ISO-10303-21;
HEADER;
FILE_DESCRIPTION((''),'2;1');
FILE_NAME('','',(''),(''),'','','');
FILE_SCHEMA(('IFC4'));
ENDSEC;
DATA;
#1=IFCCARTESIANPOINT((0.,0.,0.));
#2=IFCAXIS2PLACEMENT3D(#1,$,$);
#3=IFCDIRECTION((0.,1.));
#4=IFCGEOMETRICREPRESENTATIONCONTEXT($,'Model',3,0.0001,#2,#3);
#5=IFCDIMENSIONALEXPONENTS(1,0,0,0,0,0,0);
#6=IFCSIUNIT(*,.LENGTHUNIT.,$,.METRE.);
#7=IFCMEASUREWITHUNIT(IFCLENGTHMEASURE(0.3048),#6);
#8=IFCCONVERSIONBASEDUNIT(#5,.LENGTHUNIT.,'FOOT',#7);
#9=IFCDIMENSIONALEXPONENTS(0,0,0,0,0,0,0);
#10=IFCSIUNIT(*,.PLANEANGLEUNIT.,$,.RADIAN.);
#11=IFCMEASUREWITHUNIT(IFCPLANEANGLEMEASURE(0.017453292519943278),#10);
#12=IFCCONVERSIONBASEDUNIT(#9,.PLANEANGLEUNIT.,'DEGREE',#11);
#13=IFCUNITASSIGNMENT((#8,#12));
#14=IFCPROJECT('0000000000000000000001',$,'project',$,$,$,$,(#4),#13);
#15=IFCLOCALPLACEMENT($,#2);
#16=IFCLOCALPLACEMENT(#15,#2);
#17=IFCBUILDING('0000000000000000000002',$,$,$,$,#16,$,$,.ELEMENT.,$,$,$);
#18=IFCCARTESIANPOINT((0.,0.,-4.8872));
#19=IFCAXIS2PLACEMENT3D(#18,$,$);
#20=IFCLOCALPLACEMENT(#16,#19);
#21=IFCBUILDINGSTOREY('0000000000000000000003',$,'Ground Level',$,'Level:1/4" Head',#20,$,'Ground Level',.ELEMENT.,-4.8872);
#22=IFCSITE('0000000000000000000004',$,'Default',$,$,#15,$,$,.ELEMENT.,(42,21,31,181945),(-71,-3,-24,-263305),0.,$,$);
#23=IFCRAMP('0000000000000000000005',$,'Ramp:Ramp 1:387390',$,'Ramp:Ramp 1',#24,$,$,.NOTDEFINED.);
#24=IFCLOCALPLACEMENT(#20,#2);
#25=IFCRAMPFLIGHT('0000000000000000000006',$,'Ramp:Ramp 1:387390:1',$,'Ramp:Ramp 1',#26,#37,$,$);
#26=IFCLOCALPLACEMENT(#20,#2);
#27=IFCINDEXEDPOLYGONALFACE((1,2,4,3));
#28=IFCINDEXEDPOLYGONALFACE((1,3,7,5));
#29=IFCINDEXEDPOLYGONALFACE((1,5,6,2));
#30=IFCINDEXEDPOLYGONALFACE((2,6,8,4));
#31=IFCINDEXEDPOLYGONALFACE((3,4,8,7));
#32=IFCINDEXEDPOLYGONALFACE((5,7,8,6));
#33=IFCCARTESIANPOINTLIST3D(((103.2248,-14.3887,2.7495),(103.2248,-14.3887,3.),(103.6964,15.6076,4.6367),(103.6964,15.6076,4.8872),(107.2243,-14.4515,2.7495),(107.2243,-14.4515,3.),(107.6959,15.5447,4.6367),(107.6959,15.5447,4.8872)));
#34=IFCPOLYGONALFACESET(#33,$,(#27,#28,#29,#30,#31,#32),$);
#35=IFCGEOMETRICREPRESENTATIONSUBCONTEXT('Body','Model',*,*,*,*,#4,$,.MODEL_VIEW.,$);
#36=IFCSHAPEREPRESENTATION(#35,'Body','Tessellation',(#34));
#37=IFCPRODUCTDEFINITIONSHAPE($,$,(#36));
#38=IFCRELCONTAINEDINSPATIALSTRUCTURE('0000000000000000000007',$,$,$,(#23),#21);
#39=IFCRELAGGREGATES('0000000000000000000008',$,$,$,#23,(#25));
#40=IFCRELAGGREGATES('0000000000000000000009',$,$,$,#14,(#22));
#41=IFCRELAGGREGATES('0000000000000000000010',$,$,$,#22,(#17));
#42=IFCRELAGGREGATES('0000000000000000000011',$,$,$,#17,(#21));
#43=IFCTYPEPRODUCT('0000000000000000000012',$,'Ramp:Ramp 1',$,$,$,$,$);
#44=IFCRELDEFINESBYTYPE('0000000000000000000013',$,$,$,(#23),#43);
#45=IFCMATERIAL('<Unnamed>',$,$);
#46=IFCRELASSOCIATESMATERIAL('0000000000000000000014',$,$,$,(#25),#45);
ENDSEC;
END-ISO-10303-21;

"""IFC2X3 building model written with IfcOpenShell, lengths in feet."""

from ifc_helpers import new_model, entity, si_unit, converted_unit, direction, frame, origin, place, context, subcontext, project, spatial, polyline, outline, extrude, material, type_object, element, aggregate, save


model = new_model("IFC2X3")

# Units and contexts
model_context = context("Model", 3, precision=0.0001, world=origin(), true_north=direction((0.0, 1.0)))
body_context = subcontext(model_context, "Body", "Model", "MODEL_VIEW")
ifc_project = project(units=[converted_unit("LENGTHUNIT", "FOOT", entity("IfcLengthMeasure", 0.3048), si_unit("LENGTHUNIT", "METRE"), dimensions=[1, 0, 0, 0, 0, 0, 0]), converted_unit("PLANEANGLEUNIT", "DEGREE", entity("IfcPlaneAngleMeasure", 0.017453292519943278), si_unit("PLANEANGLEUNIT", "RADIAN"), dimensions=[0, 0, 0, 0, 0, 0, 0])], contexts=[model_context])

# Site, building, storey
site_placement = place(None, origin())
site = spatial("IfcSite", under=ifc_project, at=site_placement, Name="Default", CompositionType="ELEMENT", RefLatitude=(42, 21, 31, 181945), RefLongitude=(-71, -3, -24, -263305), RefElevation=0.0)
building_placement = place(site_placement, origin())
building = spatial("IfcBuilding", under=site, at=building_placement, CompositionType="ELEMENT")
storey_placement = place(building_placement, frame((0.0, 0.0, -4.8872)))
storey = spatial("IfcBuildingStorey", under=building, at=storey_placement, Name="Ground Level", ObjectType="Level:1/4\" Head", LongName="Ground Level", CompositionType="ELEMENT", Elevation=-4.8872)

# Shared definitions
ifc_material = material(Name="<Unnamed>")

# Ramp, ramp flight
type_product_1 = type_object("IfcTypeProduct", Name="Ramp:Ramp 1")
ramp_placement = place(storey_placement, origin())
ramp = element("IfcRamp", 1, at=ramp_placement, inside=storey, type_object=type_product_1, Name="Ramp:Ramp 1:387390", ObjectType="Ramp:Ramp 1", ShapeType="NOTDEFINED")
ramp_flight_placement = place(ramp_placement, origin())
ramp_flight = element("IfcRampFlight", 2, at=ramp_flight_placement, material=ifc_material, Name="Ramp:Ramp 1:387390:1", ObjectType="Ramp:Ramp 1", context=body_context, shape_type="SweptSolid", body=[
    extrude(outline(polyline([(0.8183, -15.0), (1.0688, -15.0), (-0.8183, 15.0), (-1.0688, 15.0), (0.8183, -15.0)])), frame((103.4606, 0.6095, 3.8183), z_axis=(0.999876, -0.015721, 0.0), x_axis=(0.0, 0.0, -1.0)), (0.0, 0.0, 1.0), 4.0),
])

aggregate(ramp, [ramp_flight])

save(model, "model.ifc")
